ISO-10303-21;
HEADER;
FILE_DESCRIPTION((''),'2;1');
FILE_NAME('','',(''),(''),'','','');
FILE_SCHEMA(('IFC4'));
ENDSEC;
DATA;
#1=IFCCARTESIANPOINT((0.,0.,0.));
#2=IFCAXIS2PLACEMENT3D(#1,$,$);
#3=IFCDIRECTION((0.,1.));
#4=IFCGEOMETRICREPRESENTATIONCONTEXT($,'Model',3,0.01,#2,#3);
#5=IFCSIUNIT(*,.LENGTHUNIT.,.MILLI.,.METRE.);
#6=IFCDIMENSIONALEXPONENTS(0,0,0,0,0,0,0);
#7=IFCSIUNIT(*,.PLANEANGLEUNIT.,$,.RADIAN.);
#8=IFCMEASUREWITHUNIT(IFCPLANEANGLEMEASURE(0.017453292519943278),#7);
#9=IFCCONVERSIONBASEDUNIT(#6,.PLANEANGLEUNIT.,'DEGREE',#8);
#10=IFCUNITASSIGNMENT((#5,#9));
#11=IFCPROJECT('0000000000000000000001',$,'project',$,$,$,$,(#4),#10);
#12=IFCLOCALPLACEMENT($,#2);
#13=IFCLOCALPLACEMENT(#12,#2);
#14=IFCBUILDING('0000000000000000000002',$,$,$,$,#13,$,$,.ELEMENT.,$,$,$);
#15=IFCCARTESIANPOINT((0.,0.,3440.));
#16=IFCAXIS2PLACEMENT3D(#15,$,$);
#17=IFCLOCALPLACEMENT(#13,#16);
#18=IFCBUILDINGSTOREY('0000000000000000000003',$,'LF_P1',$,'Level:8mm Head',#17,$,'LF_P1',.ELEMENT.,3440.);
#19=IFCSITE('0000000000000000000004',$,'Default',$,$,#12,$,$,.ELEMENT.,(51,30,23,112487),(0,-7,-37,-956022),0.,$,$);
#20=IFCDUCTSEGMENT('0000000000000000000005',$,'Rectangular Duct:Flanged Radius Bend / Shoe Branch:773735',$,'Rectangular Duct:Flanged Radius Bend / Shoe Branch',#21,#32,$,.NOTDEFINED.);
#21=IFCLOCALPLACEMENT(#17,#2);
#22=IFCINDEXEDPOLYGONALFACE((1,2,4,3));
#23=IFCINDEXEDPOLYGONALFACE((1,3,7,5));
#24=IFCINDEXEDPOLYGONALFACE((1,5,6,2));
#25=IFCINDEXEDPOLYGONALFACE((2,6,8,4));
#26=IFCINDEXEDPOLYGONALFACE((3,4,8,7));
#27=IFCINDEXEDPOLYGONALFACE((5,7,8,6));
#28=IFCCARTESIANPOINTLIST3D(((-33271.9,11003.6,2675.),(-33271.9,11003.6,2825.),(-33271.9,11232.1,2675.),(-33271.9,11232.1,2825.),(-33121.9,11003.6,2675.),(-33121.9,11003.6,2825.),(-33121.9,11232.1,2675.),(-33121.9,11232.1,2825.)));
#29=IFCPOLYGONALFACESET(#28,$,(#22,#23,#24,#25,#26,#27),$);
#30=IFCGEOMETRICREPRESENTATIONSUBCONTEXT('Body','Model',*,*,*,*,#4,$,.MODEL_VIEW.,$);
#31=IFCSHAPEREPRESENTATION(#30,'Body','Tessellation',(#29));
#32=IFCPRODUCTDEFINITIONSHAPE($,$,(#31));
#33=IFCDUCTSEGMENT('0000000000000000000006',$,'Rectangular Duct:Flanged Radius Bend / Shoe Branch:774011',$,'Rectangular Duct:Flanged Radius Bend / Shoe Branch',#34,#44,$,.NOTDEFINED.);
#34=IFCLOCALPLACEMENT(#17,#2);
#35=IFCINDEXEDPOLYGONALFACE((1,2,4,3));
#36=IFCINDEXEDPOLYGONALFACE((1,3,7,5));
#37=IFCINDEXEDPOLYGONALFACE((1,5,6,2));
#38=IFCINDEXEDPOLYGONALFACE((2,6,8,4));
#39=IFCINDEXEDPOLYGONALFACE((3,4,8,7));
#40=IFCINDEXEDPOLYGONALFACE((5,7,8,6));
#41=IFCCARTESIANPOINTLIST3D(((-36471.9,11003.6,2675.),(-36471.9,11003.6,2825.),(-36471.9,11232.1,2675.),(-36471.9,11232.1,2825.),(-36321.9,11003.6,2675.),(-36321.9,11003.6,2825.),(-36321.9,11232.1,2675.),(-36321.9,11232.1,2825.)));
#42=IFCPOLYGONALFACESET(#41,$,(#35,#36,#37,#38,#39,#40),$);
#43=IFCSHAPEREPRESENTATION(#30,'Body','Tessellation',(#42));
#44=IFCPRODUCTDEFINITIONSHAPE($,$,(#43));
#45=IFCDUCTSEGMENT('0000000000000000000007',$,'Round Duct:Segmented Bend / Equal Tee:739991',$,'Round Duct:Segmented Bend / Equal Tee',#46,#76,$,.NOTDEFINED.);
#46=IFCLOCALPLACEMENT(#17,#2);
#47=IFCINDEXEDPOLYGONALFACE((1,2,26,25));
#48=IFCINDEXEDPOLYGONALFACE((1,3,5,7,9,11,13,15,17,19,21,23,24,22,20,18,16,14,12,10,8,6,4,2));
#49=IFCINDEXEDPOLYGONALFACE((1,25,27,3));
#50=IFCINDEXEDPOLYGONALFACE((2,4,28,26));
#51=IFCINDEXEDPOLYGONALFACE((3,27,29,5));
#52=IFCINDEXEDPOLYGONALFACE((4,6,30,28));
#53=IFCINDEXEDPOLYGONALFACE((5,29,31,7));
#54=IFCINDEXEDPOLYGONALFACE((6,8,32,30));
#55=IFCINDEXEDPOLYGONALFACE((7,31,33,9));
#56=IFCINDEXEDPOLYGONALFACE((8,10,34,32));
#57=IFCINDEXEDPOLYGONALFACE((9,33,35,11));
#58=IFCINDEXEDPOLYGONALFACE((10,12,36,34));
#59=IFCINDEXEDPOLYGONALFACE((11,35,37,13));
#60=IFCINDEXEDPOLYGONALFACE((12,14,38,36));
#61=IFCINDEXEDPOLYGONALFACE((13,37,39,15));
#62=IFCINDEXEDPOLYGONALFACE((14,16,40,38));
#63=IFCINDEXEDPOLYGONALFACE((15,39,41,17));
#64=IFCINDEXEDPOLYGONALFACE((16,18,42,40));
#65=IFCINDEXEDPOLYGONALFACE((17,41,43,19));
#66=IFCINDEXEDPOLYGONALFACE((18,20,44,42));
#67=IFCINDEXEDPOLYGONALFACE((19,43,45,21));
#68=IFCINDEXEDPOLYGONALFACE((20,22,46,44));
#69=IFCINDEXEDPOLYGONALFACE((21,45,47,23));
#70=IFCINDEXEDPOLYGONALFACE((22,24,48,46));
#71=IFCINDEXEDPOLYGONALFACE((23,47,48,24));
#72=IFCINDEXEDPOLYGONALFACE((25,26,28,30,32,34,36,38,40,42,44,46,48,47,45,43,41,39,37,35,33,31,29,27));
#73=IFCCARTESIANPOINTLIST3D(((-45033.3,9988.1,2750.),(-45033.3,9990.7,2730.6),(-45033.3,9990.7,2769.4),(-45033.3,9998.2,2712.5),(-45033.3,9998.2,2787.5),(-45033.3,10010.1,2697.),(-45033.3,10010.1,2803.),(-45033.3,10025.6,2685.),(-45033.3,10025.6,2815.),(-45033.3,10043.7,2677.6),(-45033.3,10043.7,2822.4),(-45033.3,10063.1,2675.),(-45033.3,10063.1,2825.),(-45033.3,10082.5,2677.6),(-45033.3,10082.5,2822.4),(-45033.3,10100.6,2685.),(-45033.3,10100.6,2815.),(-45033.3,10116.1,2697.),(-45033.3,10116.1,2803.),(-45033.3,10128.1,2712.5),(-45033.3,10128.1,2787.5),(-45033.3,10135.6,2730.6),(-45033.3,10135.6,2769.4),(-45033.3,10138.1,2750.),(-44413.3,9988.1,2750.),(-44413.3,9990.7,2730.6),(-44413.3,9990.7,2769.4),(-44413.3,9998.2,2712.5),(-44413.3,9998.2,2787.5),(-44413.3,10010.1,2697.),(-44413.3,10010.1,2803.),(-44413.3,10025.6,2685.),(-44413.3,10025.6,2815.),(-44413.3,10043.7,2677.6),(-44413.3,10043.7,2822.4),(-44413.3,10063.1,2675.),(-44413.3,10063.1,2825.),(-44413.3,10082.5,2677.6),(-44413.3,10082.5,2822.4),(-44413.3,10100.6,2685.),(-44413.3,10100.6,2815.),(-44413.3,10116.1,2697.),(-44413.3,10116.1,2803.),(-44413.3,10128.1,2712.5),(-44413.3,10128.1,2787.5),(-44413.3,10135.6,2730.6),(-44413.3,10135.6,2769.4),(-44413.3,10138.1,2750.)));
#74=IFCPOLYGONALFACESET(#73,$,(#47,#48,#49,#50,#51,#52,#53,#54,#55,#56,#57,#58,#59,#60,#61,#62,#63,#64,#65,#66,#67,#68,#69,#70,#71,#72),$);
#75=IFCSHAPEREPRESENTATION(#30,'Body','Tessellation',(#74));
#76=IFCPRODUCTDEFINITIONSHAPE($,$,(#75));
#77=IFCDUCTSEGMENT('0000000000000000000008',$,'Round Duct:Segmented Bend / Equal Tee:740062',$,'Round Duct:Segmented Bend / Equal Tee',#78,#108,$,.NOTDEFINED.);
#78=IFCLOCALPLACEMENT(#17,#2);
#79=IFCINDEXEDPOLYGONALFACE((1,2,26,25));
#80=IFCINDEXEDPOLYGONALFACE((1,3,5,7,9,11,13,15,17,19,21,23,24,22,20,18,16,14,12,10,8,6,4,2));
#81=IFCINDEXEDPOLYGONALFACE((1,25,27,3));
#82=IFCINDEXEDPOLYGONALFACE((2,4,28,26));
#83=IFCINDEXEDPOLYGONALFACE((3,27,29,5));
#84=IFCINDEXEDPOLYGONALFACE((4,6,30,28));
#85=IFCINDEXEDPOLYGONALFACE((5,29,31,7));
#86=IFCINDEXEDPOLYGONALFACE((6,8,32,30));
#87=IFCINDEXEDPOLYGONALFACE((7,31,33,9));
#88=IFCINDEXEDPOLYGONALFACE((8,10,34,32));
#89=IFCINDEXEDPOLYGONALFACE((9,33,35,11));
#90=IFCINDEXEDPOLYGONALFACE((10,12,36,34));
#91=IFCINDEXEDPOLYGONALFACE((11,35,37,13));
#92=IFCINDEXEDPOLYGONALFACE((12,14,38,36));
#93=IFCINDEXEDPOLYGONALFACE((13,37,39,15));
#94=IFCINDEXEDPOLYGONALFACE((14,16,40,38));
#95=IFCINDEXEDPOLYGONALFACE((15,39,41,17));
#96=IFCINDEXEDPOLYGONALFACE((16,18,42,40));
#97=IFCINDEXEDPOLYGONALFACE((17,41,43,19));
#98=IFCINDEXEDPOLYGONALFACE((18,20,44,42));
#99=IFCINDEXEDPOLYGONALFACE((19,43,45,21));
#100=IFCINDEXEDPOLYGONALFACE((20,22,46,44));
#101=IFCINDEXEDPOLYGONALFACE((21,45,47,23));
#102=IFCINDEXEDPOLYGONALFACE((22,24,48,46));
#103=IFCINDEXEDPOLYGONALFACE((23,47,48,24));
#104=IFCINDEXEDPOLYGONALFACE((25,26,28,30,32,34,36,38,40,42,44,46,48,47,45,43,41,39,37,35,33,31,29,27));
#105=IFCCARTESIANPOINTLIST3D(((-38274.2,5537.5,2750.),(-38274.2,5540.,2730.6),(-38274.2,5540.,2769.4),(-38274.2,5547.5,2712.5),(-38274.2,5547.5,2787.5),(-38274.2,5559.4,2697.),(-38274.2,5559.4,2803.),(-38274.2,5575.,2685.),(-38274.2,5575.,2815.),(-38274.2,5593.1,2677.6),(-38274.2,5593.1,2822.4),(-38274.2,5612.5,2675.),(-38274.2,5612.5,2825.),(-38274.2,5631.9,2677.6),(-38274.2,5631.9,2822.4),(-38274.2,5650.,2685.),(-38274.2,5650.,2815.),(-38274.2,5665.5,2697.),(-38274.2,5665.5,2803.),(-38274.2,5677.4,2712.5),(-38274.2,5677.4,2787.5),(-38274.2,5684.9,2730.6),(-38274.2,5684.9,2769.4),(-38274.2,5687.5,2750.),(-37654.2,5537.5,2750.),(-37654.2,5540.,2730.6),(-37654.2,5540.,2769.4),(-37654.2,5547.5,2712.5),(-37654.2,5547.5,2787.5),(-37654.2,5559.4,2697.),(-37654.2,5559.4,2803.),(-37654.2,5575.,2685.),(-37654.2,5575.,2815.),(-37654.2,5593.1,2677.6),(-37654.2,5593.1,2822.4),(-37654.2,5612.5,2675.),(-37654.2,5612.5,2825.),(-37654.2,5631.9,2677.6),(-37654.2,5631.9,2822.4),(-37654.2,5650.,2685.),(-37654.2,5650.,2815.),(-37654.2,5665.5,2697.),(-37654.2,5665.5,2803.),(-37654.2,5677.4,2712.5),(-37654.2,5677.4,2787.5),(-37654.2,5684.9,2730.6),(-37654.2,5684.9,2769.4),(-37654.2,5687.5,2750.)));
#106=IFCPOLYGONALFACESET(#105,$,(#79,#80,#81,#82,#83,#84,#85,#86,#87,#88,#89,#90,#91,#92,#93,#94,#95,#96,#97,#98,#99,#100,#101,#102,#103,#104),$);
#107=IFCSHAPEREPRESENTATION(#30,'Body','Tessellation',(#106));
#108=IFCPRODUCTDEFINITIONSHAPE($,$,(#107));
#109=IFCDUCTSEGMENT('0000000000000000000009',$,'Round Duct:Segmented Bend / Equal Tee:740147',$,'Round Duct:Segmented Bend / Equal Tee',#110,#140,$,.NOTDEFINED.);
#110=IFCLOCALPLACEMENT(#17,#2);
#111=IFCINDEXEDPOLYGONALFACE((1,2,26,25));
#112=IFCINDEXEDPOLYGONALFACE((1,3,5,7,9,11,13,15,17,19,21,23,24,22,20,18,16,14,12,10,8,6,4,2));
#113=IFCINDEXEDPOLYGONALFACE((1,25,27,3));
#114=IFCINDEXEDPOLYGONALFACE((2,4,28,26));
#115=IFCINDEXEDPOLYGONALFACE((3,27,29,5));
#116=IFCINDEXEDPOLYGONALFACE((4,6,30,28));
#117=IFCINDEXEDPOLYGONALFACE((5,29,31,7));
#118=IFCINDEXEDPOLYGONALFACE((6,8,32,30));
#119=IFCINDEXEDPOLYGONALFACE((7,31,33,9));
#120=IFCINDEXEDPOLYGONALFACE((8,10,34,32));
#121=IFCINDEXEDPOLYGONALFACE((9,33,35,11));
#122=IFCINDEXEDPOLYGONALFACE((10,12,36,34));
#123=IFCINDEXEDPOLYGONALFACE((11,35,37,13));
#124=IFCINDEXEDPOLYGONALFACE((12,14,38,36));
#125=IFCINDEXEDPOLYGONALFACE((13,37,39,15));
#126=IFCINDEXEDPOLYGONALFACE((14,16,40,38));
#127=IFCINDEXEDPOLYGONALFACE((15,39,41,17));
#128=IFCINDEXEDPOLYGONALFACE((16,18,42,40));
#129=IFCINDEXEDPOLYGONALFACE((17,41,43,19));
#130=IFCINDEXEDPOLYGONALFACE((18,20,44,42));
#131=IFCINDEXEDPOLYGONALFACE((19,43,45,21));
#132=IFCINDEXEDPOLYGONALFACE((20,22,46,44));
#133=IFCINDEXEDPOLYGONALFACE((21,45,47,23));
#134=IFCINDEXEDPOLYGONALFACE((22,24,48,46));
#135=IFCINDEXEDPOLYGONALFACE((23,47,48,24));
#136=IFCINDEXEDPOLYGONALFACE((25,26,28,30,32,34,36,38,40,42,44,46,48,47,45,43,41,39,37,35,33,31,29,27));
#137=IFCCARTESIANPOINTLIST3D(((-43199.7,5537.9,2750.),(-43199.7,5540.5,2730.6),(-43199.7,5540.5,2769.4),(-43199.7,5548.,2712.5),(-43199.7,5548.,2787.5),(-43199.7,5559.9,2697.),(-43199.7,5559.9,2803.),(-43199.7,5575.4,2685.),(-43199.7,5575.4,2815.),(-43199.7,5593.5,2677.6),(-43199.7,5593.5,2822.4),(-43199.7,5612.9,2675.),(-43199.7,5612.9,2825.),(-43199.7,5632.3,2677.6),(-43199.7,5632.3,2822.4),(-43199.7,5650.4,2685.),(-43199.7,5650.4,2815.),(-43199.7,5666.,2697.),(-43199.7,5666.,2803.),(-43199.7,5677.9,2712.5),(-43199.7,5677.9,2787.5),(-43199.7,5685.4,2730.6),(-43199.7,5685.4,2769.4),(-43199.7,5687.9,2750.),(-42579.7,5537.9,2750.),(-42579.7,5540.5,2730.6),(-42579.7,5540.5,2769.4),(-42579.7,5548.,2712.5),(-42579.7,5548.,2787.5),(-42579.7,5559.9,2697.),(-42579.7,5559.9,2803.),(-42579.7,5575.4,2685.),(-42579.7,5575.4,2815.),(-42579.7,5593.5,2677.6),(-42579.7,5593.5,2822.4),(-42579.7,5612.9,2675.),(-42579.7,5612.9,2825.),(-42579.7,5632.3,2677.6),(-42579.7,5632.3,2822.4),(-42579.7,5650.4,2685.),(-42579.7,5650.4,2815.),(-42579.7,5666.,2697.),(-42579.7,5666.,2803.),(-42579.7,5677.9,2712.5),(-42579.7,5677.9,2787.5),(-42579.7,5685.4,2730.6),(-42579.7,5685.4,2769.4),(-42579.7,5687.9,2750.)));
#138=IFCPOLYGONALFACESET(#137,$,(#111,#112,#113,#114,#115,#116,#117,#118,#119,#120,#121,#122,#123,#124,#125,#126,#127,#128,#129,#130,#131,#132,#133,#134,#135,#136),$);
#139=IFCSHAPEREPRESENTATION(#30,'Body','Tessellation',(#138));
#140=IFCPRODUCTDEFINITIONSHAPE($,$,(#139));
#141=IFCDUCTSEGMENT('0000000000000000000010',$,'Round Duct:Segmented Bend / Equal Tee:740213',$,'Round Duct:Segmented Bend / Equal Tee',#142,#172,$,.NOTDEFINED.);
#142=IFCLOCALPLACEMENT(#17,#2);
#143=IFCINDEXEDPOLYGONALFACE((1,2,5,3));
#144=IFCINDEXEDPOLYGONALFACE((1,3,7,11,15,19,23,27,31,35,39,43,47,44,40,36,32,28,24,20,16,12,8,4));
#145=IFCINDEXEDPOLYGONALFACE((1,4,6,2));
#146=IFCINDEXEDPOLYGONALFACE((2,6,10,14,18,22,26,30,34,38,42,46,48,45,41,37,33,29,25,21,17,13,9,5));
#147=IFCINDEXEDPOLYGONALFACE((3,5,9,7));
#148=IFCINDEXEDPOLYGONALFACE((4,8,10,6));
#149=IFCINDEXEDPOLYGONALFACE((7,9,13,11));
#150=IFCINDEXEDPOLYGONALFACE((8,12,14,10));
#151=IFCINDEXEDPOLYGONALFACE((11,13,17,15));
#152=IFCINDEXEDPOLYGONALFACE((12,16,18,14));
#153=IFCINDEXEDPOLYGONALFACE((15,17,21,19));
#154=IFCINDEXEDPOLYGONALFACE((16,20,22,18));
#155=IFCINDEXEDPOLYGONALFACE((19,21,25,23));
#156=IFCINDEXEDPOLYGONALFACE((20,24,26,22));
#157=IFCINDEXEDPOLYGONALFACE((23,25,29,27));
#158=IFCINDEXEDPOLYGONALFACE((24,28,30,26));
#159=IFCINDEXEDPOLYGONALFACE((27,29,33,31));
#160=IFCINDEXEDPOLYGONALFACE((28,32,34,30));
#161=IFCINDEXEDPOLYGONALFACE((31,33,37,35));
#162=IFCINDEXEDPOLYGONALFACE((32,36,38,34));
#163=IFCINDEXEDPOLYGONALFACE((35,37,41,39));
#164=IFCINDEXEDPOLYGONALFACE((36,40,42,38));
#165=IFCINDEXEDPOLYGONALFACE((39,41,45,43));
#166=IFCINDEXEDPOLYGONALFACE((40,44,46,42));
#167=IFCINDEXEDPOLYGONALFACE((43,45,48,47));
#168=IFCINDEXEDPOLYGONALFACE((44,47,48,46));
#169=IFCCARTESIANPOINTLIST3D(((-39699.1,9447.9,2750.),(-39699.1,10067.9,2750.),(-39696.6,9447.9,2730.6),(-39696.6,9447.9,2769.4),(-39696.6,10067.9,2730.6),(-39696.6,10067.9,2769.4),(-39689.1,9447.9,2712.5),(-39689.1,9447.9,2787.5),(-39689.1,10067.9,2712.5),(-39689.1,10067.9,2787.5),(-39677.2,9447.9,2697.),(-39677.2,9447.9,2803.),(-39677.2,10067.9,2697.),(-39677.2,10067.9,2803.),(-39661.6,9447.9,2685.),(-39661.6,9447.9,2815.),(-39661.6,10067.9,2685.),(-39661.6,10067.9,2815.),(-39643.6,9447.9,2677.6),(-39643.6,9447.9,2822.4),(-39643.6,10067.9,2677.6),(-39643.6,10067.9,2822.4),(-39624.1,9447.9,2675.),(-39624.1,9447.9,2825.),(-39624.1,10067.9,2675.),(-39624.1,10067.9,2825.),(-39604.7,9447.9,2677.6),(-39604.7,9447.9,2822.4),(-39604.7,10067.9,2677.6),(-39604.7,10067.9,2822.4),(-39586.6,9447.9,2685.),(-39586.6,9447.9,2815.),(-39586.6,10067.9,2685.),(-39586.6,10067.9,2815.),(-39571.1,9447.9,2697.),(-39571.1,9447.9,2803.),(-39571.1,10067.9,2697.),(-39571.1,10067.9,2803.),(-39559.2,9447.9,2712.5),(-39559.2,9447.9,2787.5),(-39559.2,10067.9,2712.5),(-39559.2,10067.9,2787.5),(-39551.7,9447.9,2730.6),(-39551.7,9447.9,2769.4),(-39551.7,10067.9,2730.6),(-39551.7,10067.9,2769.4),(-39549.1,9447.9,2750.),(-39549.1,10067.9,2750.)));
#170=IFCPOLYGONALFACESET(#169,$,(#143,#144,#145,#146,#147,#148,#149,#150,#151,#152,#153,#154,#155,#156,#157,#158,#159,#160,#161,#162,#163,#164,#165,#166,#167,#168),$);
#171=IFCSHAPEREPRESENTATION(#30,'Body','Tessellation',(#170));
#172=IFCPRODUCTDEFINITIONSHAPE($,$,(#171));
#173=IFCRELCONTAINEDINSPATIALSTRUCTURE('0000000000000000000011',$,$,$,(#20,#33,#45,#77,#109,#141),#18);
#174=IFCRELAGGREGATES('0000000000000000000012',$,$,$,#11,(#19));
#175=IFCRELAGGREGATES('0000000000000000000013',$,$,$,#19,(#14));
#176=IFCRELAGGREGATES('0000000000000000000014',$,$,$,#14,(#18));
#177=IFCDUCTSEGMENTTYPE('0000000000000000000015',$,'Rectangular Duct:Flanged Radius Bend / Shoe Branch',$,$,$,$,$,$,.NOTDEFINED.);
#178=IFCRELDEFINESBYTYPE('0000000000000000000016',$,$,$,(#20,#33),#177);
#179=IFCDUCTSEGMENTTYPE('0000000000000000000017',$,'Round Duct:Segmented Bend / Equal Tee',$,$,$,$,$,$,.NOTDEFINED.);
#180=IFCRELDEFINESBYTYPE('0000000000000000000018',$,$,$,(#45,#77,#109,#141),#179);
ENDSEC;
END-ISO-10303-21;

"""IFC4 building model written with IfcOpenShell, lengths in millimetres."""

from ifc_helpers import new_model, entity, si_unit, converted_unit, direction, frame, origin, place, context, subcontext, project, spatial, arc, indexed_curve, outline, extrude, type_object, element, save


model = new_model("IFC4")

# Units and contexts
model_context = context("Model", 3, precision=0.01, world=origin(), true_north=direction((0.0, 1.0)))
body_context = subcontext(model_context, "Body", "Model", "MODEL_VIEW")
ifc_project = project(units=[si_unit("LENGTHUNIT", "METRE", prefix="MILLI"), converted_unit("PLANEANGLEUNIT", "DEGREE", entity("IfcPlaneAngleMeasure", 0.017453292519943278), si_unit("PLANEANGLEUNIT", "RADIAN"), dimensions=[0, 0, 0, 0, 0, 0, 0])], contexts=[model_context])

# Site, building, storey
site_placement = place(None, origin())
site = spatial("IfcSite", under=ifc_project, at=site_placement, Name="Default", CompositionType="ELEMENT", RefLatitude=(51, 30, 23, 112487), RefLongitude=(0, -7, -37, -956022), RefElevation=0.0)
building_placement = place(site_placement, origin())
building = spatial("IfcBuilding", under=site, at=building_placement, CompositionType="ELEMENT")
storey_placement = place(building_placement, frame((0.0, 0.0, 3440.0)))
storey = spatial("IfcBuildingStorey", under=building, at=storey_placement, Name="LF_P1", ObjectType="Level:8mm Head", LongName="LF_P1", CompositionType="ELEMENT", Elevation=3440.0)

# Duct segments
duct_segment_type_1 = type_object("IfcDuctSegmentType", Name="Rectangular Duct:Flanged Radius Bend / Shoe Branch", PredefinedType="NOTDEFINED")
duct_segment_1_placement = place(storey_placement, origin())
element("IfcDuctSegment", 1, at=duct_segment_1_placement, inside=storey, type_object=duct_segment_type_1, Name="Rectangular Duct:Flanged Radius Bend / Shoe Branch:773735", ObjectType="Rectangular Duct:Flanged Radius Bend / Shoe Branch", PredefinedType="NOTDEFINED", context=body_context, shape_type="SweptSolid", body=[
    extrude(outline(indexed_curve([(-114.2, -75.0), (114.2, -75.0), (114.2, 75.0), (-114.2, 75.0), (-114.2, -75.0)], self_intersect=False)), frame((-33196.9, 11117.9, 2675.0), z_axis=(0.0, 0.0, 1.0), x_axis=(0.0, -1.0, 0.0)), (0.0, 0.0, 1.0), 150.0),
])
duct_segment_2_placement = place(storey_placement, origin())
element("IfcDuctSegment", 2, at=duct_segment_2_placement, inside=storey, type_object=duct_segment_type_1, Name="Rectangular Duct:Flanged Radius Bend / Shoe Branch:774011", ObjectType="Rectangular Duct:Flanged Radius Bend / Shoe Branch", PredefinedType="NOTDEFINED", context=body_context, shape_type="SweptSolid", body=[
    extrude(outline(indexed_curve([(-114.2, -75.0), (114.2, -75.0), (114.2, 75.0), (-114.2, 75.0), (-114.2, -75.0)], self_intersect=False)), frame((-36396.9, 11117.9, 2675.0), z_axis=(0.0, 0.0, 1.0), x_axis=(0.0, -1.0, 0.0)), (0.0, 0.0, 1.0), 150.0),
])
duct_segment_type_2 = type_object("IfcDuctSegmentType", Name="Round Duct:Segmented Bend / Equal Tee", PredefinedType="NOTDEFINED")
duct_segment_3_placement = place(storey_placement, origin())
element("IfcDuctSegment", 3, at=duct_segment_3_placement, inside=storey, type_object=duct_segment_type_2, Name="Round Duct:Segmented Bend / Equal Tee:739991", ObjectType="Round Duct:Segmented Bend / Equal Tee", PredefinedType="NOTDEFINED", context=body_context, shape_type="SweptSolid", body=[
    extrude(outline(indexed_curve([(75.0, 0.0), (53.0, 53.0), (0.0, 75.0), (-53.0, 53.0), (-75.0, 0.0), (-53.0, -53.0), (0.0, -75.0), (53.0, -53.0)], segments=[arc(1, 2, 3), arc(3, 4, 5), arc(5, 6, 7), arc(7, 8, 1)], self_intersect=False)), frame((-45033.3, 10063.1, 2750.0), z_axis=(1.0, 0.0, 0.0), x_axis=(0.0, -1.0, 0.0)), (0.0, 0.0, 1.0), 620.0),
])
duct_segment_4_placement = place(storey_placement, origin())
element("IfcDuctSegment", 4, at=duct_segment_4_placement, inside=storey, type_object=duct_segment_type_2, Name="Round Duct:Segmented Bend / Equal Tee:740062", ObjectType="Round Duct:Segmented Bend / Equal Tee", PredefinedType="NOTDEFINED", context=body_context, shape_type="SweptSolid", body=[
    extrude(outline(indexed_curve([(75.0, 0.0), (53.0, 53.0), (0.0, 75.0), (-53.0, 53.0), (-75.0, 0.0), (-53.0, -53.0), (0.0, -75.0), (53.0, -53.0)], segments=[arc(1, 2, 3), arc(3, 4, 5), arc(5, 6, 7), arc(7, 8, 1)], self_intersect=False)), frame((-38274.2, 5612.5, 2750.0), z_axis=(1.0, 0.0, 0.0), x_axis=(0.0, -1.0, 0.0)), (0.0, 0.0, 1.0), 620.0),
])
duct_segment_5_placement = place(storey_placement, origin())
element("IfcDuctSegment", 5, at=duct_segment_5_placement, inside=storey, type_object=duct_segment_type_2, Name="Round Duct:Segmented Bend / Equal Tee:740147", ObjectType="Round Duct:Segmented Bend / Equal Tee", PredefinedType="NOTDEFINED", context=body_context, shape_type="SweptSolid", body=[
    extrude(outline(indexed_curve([(75.0, 0.0), (53.0, 53.0), (0.0, 75.0), (-53.0, 53.0), (-75.0, 0.0), (-53.0, -53.0), (0.0, -75.0), (53.0, -53.0)], segments=[arc(1, 2, 3), arc(3, 4, 5), arc(5, 6, 7), arc(7, 8, 1)], self_intersect=False)), frame((-43199.7, 5612.9, 2750.0), z_axis=(1.0, 0.0, 0.0), x_axis=(0.0, -1.0, 0.0)), (0.0, 0.0, 1.0), 620.0),
])
duct_segment_6_placement = place(storey_placement, origin())
element("IfcDuctSegment", 6, at=duct_segment_6_placement, inside=storey, type_object=duct_segment_type_2, Name="Round Duct:Segmented Bend / Equal Tee:740213", ObjectType="Round Duct:Segmented Bend / Equal Tee", PredefinedType="NOTDEFINED", context=body_context, shape_type="SweptSolid", body=[
    extrude(outline(indexed_curve([(75.0, 0.0), (53.0, 53.0), (0.0, 75.0), (-53.0, 53.0), (-75.0, 0.0), (-53.0, -53.0), (0.0, -75.0), (53.0, -53.0)], segments=[arc(1, 2, 3), arc(3, 4, 5), arc(5, 6, 7), arc(7, 8, 1)], self_intersect=False)), frame((-39624.1, 9447.9, 2750.0), z_axis=(0.0, 1.0, 0.0), x_axis=(-1.0, 0.0, 0.0)), (0.0, 0.0, 1.0), 620.0),
])

save(model, "model.ifc")
